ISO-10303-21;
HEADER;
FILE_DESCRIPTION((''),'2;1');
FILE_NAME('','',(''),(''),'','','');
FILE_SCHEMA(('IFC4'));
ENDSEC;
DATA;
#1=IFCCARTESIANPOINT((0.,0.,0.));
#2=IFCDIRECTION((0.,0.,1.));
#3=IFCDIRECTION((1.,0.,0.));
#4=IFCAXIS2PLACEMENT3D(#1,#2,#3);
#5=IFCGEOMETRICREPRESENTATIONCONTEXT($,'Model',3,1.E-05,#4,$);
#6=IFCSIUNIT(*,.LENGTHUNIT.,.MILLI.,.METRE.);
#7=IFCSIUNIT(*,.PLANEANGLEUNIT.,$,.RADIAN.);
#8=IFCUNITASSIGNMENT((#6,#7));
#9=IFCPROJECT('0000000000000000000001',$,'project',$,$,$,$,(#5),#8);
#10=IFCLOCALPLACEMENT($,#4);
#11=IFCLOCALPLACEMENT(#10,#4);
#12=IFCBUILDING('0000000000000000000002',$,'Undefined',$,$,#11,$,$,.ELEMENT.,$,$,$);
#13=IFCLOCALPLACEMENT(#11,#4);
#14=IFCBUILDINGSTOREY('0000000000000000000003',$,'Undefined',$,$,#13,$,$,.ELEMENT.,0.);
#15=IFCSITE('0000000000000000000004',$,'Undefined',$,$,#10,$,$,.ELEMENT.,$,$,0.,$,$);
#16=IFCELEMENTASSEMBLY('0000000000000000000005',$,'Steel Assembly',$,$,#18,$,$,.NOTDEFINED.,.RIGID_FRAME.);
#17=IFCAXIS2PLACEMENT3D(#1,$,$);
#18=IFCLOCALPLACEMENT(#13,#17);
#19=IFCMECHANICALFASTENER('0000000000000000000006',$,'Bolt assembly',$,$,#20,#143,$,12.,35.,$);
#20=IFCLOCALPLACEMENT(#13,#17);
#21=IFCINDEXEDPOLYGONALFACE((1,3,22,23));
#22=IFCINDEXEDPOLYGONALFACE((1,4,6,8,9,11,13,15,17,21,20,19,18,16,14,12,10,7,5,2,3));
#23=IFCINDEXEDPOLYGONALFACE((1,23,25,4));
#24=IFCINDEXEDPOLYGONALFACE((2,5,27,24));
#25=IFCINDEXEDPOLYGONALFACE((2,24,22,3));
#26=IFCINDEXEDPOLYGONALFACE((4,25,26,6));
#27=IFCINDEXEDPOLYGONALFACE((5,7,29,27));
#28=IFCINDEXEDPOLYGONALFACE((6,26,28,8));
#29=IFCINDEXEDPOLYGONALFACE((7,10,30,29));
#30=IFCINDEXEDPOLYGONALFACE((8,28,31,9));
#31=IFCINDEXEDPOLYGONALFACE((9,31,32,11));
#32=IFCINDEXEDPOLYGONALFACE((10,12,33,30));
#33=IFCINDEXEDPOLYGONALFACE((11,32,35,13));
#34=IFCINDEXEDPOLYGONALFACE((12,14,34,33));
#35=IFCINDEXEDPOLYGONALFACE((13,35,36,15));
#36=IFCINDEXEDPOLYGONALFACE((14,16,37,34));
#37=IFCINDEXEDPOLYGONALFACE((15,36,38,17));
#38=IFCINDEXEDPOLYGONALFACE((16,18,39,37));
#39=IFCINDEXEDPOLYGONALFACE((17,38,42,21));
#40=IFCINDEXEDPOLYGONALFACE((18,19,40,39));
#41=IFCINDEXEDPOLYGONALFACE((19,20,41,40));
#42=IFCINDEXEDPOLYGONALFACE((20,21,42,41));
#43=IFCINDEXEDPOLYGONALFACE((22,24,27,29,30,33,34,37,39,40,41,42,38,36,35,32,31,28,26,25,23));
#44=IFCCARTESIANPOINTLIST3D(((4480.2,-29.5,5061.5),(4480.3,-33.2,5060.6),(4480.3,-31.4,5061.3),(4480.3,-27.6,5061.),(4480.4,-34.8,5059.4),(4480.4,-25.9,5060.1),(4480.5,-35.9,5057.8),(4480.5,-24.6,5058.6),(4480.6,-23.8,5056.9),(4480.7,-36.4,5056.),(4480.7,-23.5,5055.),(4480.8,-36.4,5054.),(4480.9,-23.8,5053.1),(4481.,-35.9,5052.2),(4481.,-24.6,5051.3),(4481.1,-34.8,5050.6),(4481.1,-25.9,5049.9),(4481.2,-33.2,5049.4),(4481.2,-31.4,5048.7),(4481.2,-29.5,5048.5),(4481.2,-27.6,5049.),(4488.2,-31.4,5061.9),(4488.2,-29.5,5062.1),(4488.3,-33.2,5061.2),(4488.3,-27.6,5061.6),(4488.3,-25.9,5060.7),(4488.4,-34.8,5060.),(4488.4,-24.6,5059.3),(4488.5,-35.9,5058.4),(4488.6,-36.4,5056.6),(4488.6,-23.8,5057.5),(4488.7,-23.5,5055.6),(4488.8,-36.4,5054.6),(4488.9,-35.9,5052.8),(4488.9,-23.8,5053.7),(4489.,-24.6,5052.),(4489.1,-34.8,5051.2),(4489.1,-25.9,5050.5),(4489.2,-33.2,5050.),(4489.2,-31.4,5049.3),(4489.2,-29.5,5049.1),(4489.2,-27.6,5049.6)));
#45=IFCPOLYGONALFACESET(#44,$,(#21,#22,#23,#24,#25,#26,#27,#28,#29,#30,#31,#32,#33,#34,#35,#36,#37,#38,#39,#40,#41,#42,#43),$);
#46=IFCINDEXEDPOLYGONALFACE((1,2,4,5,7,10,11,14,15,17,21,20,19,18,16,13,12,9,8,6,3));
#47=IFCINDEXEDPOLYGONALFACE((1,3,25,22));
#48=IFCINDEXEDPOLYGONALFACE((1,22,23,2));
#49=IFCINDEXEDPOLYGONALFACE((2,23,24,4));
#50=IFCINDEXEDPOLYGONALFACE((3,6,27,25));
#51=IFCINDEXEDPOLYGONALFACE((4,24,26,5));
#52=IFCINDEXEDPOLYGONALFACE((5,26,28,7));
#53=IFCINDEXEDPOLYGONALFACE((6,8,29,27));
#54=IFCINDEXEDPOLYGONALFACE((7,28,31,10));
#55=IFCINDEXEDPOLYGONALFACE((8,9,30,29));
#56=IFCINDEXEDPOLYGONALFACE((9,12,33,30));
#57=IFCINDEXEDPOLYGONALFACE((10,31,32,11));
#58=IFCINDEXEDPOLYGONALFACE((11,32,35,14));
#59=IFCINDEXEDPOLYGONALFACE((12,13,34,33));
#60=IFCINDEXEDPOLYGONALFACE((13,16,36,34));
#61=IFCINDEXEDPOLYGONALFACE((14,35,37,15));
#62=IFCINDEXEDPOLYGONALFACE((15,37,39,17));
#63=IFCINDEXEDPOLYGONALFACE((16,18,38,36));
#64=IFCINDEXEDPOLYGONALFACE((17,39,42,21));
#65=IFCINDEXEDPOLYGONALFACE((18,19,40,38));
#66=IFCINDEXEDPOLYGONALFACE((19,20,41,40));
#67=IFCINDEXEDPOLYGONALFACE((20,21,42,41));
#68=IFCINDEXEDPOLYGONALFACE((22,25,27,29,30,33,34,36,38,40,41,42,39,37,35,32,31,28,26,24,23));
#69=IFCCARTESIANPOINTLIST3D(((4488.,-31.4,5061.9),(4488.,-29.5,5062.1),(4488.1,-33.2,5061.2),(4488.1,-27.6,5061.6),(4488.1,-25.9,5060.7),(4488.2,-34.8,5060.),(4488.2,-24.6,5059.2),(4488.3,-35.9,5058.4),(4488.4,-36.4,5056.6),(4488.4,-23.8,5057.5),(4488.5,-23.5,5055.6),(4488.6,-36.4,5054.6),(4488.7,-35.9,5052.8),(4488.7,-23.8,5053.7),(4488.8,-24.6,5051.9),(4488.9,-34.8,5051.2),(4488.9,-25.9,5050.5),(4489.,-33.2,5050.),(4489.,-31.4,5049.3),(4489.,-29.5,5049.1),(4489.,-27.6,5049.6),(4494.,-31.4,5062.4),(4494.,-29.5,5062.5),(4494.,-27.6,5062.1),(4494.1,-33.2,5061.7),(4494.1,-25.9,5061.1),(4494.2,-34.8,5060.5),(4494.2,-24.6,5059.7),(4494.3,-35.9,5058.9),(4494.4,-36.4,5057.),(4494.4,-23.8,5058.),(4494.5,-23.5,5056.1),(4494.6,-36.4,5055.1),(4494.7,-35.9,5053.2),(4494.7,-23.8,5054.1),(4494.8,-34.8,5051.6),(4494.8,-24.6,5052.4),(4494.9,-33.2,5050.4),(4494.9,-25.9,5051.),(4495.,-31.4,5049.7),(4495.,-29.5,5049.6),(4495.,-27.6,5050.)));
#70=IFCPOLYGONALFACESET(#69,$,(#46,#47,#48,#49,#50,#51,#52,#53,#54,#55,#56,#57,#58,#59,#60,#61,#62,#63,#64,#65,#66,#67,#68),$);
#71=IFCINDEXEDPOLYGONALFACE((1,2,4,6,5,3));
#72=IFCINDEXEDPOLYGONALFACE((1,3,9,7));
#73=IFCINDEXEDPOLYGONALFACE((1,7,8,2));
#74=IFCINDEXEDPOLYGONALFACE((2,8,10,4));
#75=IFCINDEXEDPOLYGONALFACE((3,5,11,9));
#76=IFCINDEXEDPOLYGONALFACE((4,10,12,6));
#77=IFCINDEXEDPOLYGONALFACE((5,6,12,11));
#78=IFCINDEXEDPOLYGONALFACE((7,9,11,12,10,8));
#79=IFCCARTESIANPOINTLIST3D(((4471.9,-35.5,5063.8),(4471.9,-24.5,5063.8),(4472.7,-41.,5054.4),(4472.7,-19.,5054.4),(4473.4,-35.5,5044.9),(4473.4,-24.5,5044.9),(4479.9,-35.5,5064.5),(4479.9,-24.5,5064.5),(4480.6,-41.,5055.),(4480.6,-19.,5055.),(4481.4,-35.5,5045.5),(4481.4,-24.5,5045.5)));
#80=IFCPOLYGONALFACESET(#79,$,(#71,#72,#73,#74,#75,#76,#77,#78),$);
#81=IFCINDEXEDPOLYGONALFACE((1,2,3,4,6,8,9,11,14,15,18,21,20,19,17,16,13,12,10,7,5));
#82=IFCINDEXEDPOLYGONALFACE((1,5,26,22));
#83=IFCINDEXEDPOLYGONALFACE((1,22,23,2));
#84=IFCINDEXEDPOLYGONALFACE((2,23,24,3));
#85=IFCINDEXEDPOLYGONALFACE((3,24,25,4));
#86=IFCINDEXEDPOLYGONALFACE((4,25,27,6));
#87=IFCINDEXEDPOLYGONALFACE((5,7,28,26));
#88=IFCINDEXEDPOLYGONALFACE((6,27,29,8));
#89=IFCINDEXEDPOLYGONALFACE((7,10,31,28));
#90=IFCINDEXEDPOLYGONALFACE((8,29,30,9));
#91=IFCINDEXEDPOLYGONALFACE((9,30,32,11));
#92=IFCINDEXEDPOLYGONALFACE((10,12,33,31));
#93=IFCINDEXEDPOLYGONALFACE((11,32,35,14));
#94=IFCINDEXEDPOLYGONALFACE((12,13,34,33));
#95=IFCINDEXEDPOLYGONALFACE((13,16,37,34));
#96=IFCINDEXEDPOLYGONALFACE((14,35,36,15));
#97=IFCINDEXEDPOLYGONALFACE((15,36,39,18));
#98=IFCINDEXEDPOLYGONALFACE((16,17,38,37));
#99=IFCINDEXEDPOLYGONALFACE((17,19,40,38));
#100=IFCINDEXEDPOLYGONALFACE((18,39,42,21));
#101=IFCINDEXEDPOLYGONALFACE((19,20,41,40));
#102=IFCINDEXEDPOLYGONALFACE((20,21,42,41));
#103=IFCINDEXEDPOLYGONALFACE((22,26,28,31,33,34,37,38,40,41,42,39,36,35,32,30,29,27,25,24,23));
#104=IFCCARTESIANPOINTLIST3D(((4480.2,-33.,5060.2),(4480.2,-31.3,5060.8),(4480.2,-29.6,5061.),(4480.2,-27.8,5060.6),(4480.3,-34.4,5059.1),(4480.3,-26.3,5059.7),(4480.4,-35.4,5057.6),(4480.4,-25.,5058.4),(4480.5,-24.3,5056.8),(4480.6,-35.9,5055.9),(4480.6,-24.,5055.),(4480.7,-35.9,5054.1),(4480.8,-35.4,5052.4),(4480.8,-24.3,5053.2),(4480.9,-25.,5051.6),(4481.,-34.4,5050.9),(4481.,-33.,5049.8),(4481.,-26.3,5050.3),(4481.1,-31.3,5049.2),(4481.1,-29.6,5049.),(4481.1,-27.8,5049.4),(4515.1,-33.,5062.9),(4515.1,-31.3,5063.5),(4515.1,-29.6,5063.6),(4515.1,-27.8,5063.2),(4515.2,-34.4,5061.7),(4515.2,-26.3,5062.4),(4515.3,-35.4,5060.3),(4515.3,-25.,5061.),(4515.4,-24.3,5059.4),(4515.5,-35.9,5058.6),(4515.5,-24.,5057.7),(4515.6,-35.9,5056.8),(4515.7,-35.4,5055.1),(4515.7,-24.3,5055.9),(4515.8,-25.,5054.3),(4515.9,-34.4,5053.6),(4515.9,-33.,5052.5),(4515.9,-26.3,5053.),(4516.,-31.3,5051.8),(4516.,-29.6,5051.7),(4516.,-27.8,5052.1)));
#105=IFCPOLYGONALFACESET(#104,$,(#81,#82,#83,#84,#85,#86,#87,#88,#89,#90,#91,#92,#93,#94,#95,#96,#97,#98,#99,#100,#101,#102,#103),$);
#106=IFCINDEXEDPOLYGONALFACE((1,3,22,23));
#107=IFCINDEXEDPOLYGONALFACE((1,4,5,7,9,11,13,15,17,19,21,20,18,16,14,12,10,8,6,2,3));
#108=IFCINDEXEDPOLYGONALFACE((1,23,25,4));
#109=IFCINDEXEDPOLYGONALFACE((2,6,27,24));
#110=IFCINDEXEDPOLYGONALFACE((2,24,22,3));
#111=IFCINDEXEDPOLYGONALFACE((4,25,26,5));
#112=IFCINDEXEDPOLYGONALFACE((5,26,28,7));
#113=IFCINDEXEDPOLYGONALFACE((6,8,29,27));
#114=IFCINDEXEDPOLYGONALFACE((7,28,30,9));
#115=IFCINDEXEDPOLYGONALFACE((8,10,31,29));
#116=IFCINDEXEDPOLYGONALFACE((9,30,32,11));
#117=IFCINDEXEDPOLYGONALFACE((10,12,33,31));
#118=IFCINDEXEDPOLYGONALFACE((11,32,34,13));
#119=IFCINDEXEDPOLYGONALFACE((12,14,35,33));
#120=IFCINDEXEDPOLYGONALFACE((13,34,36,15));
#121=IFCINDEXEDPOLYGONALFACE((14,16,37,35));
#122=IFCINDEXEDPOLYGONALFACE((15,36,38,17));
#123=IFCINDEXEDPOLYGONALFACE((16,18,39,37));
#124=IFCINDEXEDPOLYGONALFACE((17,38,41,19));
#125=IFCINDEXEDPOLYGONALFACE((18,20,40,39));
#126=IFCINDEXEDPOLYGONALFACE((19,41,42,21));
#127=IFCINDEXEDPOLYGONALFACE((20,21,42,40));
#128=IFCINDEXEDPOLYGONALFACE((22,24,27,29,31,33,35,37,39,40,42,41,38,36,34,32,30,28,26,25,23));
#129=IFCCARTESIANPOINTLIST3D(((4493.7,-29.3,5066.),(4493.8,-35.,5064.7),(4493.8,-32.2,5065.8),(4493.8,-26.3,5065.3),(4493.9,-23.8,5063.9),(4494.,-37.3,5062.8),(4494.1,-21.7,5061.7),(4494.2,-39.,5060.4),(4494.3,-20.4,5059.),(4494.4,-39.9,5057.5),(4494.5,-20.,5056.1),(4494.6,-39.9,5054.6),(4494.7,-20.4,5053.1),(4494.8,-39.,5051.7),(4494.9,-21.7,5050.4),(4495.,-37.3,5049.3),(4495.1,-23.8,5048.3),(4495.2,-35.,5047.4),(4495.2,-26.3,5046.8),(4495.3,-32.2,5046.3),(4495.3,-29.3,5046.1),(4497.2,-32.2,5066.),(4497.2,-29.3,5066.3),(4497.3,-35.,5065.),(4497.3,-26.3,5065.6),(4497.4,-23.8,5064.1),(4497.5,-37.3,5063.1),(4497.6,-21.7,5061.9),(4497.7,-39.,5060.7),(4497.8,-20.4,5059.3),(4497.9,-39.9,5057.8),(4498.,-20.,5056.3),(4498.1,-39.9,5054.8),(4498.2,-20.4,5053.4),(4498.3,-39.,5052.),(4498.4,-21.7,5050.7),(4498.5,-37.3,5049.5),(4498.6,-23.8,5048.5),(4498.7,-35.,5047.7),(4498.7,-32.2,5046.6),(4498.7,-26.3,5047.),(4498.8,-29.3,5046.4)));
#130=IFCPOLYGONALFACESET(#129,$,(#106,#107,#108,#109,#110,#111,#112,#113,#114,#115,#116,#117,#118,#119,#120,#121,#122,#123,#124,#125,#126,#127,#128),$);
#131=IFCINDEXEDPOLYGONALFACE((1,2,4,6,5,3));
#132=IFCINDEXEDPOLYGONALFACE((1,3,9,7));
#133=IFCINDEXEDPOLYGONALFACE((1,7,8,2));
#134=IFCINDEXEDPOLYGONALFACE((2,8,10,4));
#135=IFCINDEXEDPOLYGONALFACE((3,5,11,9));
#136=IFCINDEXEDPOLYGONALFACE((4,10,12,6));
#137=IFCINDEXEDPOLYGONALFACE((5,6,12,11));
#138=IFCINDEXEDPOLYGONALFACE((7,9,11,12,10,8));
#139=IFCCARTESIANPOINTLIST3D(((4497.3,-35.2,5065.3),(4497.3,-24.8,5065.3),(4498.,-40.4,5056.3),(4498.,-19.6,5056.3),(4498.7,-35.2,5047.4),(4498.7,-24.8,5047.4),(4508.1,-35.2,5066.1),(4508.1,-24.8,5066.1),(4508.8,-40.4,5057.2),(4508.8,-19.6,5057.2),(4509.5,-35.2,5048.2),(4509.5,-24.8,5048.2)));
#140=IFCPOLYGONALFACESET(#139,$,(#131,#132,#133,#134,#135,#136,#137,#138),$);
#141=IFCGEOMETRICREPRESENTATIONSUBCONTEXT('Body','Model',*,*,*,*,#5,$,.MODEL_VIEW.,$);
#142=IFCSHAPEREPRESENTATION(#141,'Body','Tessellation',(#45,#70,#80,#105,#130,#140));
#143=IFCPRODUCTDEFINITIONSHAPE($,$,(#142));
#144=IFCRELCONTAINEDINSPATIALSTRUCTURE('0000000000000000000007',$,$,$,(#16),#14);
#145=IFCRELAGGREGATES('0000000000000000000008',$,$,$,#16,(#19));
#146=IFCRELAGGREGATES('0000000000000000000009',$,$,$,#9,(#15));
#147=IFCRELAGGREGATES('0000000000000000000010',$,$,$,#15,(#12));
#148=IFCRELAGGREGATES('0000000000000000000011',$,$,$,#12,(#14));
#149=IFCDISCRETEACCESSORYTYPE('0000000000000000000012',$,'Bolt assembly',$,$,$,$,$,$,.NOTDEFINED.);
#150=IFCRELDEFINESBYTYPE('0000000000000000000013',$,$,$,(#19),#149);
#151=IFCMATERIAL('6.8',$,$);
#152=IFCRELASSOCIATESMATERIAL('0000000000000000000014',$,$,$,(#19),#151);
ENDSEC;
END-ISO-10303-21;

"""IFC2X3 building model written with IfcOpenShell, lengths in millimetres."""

from ifc_helpers import new_model, si_unit, frame, origin_with_axes, origin_2d_with_axis, place, context, subcontext, project, spatial, polyline, circle, outline, extrude, source, transform, mapped, material, type_object, element, aggregate, save


model = new_model("IFC2X3")

# Units and contexts
model_context = context("Model", 3, precision=1e-05, world=origin_with_axes())
body_context = subcontext(model_context, "Body", "Model", "MODEL_VIEW")
ifc_project = project(units=[si_unit("LENGTHUNIT", "METRE", prefix="MILLI"), si_unit("PLANEANGLEUNIT", "RADIAN")], contexts=[model_context])

# Site, building, storey
site_placement = place(None, origin_with_axes())
site = spatial("IfcSite", under=ifc_project, at=site_placement, Name="Undefined", CompositionType="ELEMENT", RefElevation=0.0)
building_placement = place(site_placement, origin_with_axes())
building = spatial("IfcBuilding", under=site, at=building_placement, Name="Undefined", CompositionType="ELEMENT")
storey_placement = place(building_placement, origin_with_axes())
storey = spatial("IfcBuildingStorey", under=building, at=storey_placement, Name="Undefined", CompositionType="ELEMENT", Elevation=0.0)

# Element assembly, mechanical fastener
ifc_material_1 = material(Name="6.8")
discrete_accessory_type_1 = type_object("IfcDiscreteAccessoryType", Name="Bolt assembly")
shared_shape_1 = source(origin_with_axes(), body_context, "Body", "SweptSolid", [
    extrude(circle(Radius=6.5, at=origin_2d_with_axis()), frame((0.0, -10.9, 0.0), z_axis=(0.0, 1.0, 0.0), x_axis=(1.0, 0.0, 0.0)), (0.0, 0.0, 1.0), 8.0),
    extrude(circle(Radius=6.5, at=origin_2d_with_axis()), frame((0.0, -3.1, 0.0), z_axis=(0.0, 1.0, 0.0), x_axis=(1.0, 0.0, 0.0)), (0.0, 0.0, 1.0), 6.0),
    extrude(outline(polyline([(11.0, 0.0), (5.5, 9.5), (-5.5, 9.5), (-11.0, 0.0), (-5.5, -9.5), (5.5, -9.5), (11.0, 0.0)])), frame((0.0, -19.0, 0.0), z_axis=(0.0, 1.0, 0.0), x_axis=(1.0, 0.0, 0.0)), (0.0, 0.0, 1.0), 8.0),
    extrude(circle(Radius=6.0, at=origin_2d_with_axis()), frame((0.0, -11.0, 0.0), z_axis=(0.0, 1.0, 0.0), x_axis=(1.0, 0.0, 0.0)), (0.0, 0.0, 1.0), 35.0),
    extrude(circle(Radius=10.0, at=origin_2d_with_axis()), frame((0.0, 3.0, 0.0), z_axis=(0.0, 1.0, 0.0), x_axis=(1.0, 0.0, 0.0)), (0.0, 0.0, 1.0), 3.5),
    extrude(outline(polyline([(10.4, 0.0), (5.2, 9.0), (-5.2, 9.0), (-10.4, 0.0), (-5.2, -9.0), (5.2, -9.0), (10.4, 0.0)])), frame((0.0, 6.5, 0.0), z_axis=(0.0, 1.0, 0.0), x_axis=(1.0, 0.0, 0.0)), (0.0, 0.0, 1.0), 10.8),
])
assembly_1_placement = place(storey_placement, origin_with_axes())
assembly_1 = element("IfcElementAssembly", 1, at=assembly_1_placement, inside=storey, Name="Steel Assembly", AssemblyPlace="NOTDEFINED", PredefinedType="RIGID_FRAME")
mechanical_fastener_1_placement = place(assembly_1_placement, frame((4491.6, -30.0, 5055.8), z_axis=(0.076696, 0.0, -0.997054), x_axis=(0.0, 1.0, 0.0)))
mechanical_fastener_1 = element("IfcMechanicalFastener", 2, at=mechanical_fastener_1_placement, type_object=discrete_accessory_type_1, material=ifc_material_1, Name="Bolt assembly", NominalDiameter=12.0, NominalLength=35.0, context=body_context, shape_type="MappedRepresentation", body=[
    mapped(shared_shape_1, transform((0.0, 0.0, 0.0))),
])
aggregate(assembly_1, [mechanical_fastener_1])

save(model, "model.ifc")
